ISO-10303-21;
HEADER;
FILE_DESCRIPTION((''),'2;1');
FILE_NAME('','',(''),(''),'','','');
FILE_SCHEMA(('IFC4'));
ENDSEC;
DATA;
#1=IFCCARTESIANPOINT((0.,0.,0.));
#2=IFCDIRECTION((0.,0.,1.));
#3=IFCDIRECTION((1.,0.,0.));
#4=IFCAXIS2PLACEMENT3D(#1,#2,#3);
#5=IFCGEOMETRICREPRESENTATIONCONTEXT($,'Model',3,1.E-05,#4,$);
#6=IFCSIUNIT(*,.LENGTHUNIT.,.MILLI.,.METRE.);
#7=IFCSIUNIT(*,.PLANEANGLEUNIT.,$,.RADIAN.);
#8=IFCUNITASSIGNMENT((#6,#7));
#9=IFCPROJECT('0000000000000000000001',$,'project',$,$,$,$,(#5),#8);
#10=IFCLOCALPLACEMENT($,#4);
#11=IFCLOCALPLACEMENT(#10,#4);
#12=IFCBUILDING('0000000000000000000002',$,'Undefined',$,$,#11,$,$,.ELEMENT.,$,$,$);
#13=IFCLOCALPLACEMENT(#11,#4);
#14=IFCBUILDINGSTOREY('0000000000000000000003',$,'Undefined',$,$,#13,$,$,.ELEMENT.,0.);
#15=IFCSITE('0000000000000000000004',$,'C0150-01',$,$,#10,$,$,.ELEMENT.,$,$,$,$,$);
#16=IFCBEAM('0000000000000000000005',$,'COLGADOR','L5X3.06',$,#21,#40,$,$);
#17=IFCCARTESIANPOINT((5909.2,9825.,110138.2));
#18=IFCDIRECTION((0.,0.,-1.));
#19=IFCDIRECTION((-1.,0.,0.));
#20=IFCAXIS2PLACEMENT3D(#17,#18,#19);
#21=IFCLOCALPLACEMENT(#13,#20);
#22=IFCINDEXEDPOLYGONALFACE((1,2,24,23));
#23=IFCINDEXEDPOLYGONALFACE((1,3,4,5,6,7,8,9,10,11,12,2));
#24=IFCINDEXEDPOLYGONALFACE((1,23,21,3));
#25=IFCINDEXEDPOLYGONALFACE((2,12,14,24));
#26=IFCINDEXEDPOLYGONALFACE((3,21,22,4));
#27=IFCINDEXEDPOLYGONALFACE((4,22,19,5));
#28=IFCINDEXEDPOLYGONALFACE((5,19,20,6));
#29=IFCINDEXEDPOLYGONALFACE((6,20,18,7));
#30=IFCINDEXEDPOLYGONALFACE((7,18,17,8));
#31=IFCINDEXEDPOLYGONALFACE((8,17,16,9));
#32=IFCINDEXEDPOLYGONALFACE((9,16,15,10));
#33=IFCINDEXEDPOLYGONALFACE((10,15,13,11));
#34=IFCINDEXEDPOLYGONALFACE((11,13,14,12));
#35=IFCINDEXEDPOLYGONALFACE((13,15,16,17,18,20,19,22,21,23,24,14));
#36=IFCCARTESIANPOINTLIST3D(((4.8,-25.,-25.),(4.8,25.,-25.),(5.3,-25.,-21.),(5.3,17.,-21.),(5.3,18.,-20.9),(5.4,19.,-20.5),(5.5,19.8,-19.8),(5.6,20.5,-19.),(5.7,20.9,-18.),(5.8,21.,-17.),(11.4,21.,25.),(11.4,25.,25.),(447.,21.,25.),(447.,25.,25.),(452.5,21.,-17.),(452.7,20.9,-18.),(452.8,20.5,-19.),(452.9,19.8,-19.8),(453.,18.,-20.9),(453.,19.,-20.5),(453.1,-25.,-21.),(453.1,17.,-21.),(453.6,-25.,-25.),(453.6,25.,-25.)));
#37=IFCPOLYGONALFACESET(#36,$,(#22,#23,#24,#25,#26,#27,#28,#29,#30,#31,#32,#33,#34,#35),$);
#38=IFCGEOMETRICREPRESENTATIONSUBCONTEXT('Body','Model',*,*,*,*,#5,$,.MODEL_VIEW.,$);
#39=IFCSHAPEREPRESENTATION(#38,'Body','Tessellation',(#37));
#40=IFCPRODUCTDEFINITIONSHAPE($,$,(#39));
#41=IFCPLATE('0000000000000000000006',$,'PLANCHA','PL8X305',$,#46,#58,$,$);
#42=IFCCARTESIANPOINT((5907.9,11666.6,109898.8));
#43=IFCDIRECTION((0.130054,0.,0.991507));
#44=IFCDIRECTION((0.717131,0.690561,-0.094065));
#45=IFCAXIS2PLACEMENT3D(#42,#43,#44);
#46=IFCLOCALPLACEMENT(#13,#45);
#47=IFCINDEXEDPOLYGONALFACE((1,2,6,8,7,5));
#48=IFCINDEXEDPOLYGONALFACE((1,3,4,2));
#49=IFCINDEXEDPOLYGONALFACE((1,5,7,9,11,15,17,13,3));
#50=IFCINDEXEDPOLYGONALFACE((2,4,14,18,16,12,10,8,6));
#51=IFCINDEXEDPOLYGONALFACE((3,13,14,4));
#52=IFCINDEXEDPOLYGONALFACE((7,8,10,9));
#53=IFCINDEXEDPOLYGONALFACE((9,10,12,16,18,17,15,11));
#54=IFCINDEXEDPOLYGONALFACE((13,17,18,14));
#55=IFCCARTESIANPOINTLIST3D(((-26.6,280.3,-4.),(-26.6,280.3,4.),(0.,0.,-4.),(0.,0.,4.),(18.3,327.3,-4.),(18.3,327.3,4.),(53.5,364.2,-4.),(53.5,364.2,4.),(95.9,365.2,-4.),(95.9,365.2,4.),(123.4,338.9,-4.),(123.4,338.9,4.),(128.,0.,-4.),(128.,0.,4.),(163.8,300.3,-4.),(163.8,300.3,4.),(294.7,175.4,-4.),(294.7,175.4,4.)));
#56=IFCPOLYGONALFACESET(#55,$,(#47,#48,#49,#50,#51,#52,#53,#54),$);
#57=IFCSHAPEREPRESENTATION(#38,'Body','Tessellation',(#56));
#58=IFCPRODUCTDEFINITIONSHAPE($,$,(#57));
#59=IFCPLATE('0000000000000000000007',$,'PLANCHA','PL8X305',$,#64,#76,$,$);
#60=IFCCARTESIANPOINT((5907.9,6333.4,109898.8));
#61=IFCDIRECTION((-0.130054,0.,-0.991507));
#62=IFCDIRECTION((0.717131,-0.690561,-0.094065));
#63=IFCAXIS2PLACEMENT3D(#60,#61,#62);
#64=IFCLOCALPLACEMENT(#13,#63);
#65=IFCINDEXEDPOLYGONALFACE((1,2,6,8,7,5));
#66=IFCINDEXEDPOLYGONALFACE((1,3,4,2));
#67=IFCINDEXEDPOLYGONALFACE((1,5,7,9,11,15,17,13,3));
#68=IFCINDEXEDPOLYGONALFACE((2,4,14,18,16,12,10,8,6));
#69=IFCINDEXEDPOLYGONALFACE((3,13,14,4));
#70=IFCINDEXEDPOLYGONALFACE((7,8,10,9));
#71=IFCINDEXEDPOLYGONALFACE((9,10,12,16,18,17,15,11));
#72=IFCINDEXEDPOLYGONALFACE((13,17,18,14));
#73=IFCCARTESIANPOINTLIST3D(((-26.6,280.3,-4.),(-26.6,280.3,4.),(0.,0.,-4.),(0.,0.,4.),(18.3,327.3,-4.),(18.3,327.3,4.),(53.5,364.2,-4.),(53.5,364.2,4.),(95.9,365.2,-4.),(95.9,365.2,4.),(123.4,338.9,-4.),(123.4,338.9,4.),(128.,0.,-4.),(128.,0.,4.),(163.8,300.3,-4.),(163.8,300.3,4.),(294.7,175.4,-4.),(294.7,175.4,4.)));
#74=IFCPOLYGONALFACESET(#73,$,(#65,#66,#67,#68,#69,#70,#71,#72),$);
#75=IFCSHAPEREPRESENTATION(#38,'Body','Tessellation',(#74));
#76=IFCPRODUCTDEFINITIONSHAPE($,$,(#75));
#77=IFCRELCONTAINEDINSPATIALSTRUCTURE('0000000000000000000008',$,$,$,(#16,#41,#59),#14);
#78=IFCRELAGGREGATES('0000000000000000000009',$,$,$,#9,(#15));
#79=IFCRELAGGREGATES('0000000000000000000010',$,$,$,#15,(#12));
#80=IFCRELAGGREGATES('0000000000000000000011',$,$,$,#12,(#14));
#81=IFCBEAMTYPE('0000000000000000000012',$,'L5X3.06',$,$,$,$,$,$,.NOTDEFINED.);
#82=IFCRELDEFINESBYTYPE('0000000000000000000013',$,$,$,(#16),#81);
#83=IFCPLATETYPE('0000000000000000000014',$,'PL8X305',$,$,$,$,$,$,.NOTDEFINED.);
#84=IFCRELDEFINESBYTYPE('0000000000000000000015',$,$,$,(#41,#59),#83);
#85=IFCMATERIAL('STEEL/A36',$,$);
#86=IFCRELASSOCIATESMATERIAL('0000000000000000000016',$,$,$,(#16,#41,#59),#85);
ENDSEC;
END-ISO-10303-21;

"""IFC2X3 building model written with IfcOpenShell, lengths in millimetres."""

from ifc_helpers import new_model, si_unit, frame, origin_with_axes, origin_2d_with_axis, place, context, subcontext, project, spatial, polyline, l_section, outline, extrude, clip, halfspace, material, type_object, element, save


model = new_model("IFC2X3")

# Units and contexts
model_context = context("Model", 3, precision=1e-05, world=origin_with_axes())
body_context = subcontext(model_context, "Body", "Model", "MODEL_VIEW")
ifc_project = project(units=[si_unit("LENGTHUNIT", "METRE", prefix="MILLI"), si_unit("PLANEANGLEUNIT", "RADIAN")], contexts=[model_context])

# Site, building, storey
site_placement = place(None, origin_with_axes())
site = spatial("IfcSite", under=ifc_project, at=site_placement, Name="C0150-01", CompositionType="ELEMENT")
building_placement = place(site_placement, origin_with_axes())
building = spatial("IfcBuilding", under=site, at=building_placement, Name="Undefined", CompositionType="ELEMENT")
storey_placement = place(building_placement, origin_with_axes())
storey = spatial("IfcBuildingStorey", under=building, at=storey_placement, Name="Undefined", CompositionType="ELEMENT", Elevation=0.0)

# Beam
ifc_material_1 = material(Name="STEEL/A36")
beam_type = type_object("IfcBeamType", Name="L5X3.06", PredefinedType="NOTDEFINED")
beam_placement = place(storey_placement, frame((5909.2, 9825.0, 110138.2), z_axis=(0.0, 0.0, -1.0), x_axis=(-1.0, 0.0, 0.0)))
element("IfcBeam", 1, at=beam_placement, inside=storey, type_object=beam_type, material=ifc_material_1, Name="COLGADOR", Description="L5X3.06", context=body_context, shape_type="Clipping", body=[
    clip(clip(extrude(l_section(Depth=50.0, Width=50.0, Thickness=4.0, FilletRadius=4.0, at=origin_2d_with_axis()), frame((458.4, 0.0, 0.0), z_axis=(-1.0, 0.0, 0.0), x_axis=(0.0, -1.0, 0.0)), (0.0, 0.0, 1.0), 458.4), halfspace(frame((444.6, 0.0, 43.4), z_axis=(-0.991507, 0.0, -0.130054), x_axis=(0.130054, 0.0, -0.991507)), True)), halfspace(frame((13.8, 0.0, 43.4), z_axis=(0.991507, 0.0, -0.130054), x_axis=(0.0, 1.0, 0.0)), True)),
])

# Plates
plate_type_1 = type_object("IfcPlateType", Name="PL8X305", PredefinedType="NOTDEFINED")
for number, where, z_axis, x_axis, name in (
    (2, (5907.9, 11666.6, 109898.8), (0.130054, 0.0, 0.991507), (0.717131, 0.690561, -0.094065), "PLANCHA"),
    (3, (5907.9, 6333.4, 109898.8), (-0.130054, 0.0, -0.991507), (0.717131, -0.690561, -0.094065), "PLANCHA"),
):
    element("IfcPlate", number, at=place(storey_placement, frame(where, z_axis=z_axis, x_axis=x_axis)), inside=storey, type_object=plate_type_1, material=ifc_material_1, Name=name, Description="PL8X305", context=body_context, shape_type="SweptSolid", body=[
        extrude(outline(polyline([(0.0, 0.0), (128.0, 0.0), (294.7, 175.4), (163.8, 300.3), (123.4, 338.9), (95.9, 365.2), (53.5, 364.2), (18.3, 327.3), (-26.6, 280.3), (0.0, 0.0)])), frame((0.0, 0.0, -4.0), z_axis=(0.0, 0.0, 1.0), x_axis=(1.0, 0.0, 0.0)), (0.0, 0.0, 1.0), 8.0),
    ])

save(model, "model.ifc")
